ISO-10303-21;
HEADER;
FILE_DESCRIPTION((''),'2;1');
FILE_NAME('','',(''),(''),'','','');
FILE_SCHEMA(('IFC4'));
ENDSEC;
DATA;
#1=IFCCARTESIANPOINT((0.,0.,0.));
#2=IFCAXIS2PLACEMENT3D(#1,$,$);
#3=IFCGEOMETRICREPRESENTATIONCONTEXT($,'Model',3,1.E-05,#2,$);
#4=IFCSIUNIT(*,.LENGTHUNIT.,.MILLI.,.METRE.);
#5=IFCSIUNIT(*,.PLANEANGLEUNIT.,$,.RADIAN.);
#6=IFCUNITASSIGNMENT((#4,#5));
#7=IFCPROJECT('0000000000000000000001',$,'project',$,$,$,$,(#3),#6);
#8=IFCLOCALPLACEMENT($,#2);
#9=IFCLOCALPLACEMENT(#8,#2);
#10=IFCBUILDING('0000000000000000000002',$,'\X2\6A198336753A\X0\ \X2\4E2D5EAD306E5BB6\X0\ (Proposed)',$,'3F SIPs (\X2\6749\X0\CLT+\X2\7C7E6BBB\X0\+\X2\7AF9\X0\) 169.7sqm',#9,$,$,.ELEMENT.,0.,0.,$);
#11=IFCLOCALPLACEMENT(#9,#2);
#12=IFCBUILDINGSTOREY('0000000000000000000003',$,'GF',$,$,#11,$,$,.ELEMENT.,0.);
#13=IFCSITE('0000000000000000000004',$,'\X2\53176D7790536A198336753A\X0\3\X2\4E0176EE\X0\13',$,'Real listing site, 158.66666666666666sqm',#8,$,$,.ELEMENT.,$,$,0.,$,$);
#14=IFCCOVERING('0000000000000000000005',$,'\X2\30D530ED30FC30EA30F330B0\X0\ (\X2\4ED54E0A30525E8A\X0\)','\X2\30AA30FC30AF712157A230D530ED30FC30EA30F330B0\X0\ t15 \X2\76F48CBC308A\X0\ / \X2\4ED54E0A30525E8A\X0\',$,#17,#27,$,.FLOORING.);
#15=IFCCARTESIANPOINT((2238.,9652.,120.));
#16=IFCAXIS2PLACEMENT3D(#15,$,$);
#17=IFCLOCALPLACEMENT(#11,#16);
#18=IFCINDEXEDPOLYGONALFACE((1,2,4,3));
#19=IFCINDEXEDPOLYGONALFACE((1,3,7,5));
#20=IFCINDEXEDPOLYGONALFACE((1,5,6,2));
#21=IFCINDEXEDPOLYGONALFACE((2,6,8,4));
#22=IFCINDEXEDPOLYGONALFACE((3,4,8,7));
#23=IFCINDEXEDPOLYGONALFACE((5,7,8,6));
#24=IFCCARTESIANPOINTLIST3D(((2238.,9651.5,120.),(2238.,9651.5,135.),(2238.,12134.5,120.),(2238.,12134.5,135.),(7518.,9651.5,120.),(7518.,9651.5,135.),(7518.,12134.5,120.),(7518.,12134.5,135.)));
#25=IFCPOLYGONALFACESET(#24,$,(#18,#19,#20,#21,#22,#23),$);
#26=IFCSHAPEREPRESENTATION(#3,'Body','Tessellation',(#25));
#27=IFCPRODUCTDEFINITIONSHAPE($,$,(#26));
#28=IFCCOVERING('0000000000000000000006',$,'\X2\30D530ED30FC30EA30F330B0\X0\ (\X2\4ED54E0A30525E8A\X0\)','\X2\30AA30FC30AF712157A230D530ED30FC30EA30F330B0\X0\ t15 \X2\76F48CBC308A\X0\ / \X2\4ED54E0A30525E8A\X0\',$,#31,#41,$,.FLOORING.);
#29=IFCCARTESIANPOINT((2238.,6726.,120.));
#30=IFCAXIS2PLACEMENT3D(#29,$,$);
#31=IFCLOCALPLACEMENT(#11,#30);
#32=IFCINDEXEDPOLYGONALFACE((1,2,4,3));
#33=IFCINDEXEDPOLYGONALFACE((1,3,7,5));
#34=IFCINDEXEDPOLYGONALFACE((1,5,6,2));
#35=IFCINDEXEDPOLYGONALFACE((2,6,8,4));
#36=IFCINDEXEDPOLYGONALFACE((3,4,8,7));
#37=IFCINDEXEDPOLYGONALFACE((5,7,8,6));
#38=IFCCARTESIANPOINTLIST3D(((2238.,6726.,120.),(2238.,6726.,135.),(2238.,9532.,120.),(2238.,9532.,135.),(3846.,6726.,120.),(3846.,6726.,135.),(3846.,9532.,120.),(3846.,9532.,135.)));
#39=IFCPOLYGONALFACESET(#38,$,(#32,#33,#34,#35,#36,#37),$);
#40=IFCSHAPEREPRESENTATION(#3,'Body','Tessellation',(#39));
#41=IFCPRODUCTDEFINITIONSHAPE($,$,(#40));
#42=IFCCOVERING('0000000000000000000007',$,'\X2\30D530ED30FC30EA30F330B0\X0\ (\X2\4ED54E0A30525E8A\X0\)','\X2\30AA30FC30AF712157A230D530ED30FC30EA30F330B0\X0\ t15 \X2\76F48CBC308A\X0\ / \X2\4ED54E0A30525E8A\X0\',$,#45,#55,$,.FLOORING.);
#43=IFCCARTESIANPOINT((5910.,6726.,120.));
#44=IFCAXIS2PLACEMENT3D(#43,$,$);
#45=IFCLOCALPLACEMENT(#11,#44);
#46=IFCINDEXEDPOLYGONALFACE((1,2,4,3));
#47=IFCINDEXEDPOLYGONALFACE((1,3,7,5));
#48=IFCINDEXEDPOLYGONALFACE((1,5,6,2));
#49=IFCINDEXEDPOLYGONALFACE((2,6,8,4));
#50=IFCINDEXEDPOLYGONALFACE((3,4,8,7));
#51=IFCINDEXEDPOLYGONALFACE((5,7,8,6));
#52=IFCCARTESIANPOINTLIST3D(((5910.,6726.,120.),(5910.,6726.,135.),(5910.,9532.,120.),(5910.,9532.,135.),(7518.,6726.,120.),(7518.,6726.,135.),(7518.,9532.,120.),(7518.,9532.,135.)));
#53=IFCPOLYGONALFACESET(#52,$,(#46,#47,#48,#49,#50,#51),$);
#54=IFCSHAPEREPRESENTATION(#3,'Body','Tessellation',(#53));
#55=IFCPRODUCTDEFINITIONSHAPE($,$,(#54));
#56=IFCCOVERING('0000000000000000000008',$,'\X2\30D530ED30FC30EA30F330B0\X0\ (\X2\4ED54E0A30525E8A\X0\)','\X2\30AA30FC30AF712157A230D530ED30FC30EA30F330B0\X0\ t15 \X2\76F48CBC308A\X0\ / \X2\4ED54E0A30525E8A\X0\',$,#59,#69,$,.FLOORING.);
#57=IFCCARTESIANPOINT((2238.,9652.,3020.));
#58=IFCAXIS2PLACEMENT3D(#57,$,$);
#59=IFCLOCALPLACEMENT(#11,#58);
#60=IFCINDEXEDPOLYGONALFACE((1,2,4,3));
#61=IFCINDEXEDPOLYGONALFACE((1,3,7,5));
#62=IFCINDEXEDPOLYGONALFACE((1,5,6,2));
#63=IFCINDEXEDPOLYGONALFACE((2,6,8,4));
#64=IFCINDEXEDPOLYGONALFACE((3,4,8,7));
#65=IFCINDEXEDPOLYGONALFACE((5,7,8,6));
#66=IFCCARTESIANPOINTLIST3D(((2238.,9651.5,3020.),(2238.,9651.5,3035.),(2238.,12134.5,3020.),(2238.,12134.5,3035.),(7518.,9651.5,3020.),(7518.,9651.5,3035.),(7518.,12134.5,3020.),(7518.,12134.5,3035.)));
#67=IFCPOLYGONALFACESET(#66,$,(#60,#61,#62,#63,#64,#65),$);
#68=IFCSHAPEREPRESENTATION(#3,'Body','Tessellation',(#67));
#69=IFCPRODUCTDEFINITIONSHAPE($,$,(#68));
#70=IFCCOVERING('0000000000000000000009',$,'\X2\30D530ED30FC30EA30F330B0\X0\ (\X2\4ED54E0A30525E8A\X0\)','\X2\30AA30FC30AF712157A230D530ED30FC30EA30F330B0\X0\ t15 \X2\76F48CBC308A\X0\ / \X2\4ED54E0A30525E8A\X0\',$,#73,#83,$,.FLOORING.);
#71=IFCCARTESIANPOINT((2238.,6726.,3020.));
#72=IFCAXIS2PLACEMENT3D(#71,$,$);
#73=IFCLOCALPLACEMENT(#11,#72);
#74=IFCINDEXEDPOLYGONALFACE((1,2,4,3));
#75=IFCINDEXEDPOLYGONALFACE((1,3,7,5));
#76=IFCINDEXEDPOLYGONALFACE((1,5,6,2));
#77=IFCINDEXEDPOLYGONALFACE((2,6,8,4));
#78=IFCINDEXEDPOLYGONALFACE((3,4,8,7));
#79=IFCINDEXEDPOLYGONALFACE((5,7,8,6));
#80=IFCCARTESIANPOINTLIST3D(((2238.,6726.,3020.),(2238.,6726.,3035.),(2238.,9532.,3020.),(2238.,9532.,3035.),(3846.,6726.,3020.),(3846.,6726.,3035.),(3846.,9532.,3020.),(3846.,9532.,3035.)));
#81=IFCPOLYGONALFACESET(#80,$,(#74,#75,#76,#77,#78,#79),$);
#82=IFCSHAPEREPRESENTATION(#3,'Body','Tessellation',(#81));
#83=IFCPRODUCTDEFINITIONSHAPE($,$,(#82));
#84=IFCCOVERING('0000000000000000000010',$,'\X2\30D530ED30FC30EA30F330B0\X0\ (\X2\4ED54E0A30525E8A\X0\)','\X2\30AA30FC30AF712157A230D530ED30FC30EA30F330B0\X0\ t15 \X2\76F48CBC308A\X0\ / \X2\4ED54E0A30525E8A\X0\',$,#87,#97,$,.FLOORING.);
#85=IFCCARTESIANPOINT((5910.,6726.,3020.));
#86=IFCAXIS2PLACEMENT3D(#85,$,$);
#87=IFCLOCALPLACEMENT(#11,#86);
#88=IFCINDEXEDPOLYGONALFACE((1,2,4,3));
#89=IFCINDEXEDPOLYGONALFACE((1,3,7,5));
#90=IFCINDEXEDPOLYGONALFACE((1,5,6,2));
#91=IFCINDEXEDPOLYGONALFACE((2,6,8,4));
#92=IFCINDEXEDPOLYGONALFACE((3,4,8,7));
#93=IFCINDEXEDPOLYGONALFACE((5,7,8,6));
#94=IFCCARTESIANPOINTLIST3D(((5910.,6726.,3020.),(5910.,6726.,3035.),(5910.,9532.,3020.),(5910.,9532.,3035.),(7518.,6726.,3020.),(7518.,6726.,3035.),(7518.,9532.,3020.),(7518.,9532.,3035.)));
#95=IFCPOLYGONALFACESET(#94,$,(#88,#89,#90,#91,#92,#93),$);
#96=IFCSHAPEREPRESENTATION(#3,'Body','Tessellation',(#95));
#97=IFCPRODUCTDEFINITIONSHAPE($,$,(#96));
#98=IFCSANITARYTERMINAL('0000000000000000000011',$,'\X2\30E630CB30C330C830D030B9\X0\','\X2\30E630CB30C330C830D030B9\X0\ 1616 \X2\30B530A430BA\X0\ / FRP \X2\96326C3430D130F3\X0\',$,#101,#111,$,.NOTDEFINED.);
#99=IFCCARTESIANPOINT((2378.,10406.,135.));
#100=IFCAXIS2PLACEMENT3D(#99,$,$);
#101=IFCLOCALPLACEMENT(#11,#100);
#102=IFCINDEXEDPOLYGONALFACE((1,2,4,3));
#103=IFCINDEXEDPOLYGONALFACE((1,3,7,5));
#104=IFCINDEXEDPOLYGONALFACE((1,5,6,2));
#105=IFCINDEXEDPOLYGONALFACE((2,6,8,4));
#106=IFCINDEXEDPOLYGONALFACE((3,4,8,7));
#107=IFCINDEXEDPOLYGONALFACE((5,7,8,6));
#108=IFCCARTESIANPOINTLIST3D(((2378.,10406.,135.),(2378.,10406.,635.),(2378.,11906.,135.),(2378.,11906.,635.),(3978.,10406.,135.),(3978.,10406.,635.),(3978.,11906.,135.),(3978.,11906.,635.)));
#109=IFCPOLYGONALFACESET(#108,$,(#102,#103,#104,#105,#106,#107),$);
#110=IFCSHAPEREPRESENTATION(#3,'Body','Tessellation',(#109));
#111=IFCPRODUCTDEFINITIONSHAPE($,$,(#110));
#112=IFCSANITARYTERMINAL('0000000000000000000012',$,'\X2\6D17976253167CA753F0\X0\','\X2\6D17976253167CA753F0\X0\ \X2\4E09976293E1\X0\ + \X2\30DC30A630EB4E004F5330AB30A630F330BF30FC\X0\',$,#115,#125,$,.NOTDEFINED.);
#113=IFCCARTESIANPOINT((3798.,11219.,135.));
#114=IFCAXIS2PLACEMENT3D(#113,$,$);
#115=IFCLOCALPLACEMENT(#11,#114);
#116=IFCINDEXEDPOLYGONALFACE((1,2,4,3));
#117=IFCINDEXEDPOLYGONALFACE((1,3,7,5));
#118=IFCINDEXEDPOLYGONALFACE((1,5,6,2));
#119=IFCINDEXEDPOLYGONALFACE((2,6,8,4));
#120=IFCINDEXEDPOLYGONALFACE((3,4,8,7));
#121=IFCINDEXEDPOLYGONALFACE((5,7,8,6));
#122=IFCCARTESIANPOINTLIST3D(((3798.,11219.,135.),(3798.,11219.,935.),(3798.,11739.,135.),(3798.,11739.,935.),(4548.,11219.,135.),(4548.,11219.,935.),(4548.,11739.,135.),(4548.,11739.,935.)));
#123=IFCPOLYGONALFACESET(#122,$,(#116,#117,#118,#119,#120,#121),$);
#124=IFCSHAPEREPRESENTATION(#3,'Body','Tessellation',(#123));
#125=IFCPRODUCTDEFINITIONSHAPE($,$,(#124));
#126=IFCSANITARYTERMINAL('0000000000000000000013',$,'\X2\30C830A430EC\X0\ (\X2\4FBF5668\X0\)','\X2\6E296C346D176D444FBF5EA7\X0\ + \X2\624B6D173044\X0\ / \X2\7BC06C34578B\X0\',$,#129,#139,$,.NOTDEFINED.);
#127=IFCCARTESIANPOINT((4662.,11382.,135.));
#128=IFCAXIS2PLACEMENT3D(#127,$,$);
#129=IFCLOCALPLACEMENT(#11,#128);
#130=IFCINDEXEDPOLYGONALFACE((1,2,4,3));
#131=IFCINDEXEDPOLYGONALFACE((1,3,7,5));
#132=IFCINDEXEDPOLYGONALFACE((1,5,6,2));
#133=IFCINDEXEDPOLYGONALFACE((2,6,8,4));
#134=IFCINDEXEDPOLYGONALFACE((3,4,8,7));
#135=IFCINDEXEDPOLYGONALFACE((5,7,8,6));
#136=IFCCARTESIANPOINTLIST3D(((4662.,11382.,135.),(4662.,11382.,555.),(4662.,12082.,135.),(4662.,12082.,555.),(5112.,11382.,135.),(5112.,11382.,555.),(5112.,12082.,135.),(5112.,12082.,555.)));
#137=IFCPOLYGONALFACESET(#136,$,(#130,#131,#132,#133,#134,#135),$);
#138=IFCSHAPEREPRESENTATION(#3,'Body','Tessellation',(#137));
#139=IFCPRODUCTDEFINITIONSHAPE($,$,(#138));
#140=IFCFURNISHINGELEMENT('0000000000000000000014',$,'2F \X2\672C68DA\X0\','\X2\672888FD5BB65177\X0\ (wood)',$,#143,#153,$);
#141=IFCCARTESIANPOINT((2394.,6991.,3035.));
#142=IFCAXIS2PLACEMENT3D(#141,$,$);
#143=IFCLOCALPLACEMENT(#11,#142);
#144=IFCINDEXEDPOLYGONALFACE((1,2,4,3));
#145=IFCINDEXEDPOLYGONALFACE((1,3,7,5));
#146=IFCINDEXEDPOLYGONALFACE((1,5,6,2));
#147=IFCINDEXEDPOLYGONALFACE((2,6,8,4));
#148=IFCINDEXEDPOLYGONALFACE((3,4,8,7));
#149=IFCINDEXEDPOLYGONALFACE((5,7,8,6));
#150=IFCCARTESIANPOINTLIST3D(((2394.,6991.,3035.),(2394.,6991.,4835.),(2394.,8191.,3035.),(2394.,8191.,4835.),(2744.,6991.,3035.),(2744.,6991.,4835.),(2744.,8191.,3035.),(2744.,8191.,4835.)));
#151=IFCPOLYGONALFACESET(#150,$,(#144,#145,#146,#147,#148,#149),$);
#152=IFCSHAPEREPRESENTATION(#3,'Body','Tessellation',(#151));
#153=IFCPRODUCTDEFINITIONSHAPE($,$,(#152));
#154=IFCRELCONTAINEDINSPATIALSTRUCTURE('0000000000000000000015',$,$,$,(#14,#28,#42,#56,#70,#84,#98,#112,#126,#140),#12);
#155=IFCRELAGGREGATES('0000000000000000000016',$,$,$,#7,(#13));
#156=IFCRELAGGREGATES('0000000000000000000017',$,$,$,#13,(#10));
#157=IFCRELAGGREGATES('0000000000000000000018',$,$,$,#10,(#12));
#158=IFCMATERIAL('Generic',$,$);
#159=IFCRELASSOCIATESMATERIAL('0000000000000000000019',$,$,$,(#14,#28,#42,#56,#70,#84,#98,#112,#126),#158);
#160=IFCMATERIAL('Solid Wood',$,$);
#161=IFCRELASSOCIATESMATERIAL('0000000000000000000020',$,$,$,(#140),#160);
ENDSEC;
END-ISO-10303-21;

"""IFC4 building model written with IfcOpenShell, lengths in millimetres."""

from ifc_helpers import new_model, si_unit, frame, frame_2d, origin, place, context, project, spatial, rectangle, extrude, material, element, save


model = new_model("IFC4")

# Units and contexts
model_context = context("Model", 3, precision=1e-05, world=origin())
ifc_project = project(units=[si_unit("LENGTHUNIT", "METRE", prefix="MILLI"), si_unit("PLANEANGLEUNIT", "RADIAN")], contexts=[model_context])

# Site, building, storey
site_placement = place(None, origin())
site = spatial("IfcSite", under=ifc_project, at=site_placement, Name="北海道標茶町3丁目13", ObjectType="Real listing site, 158.66666666666666sqm", CompositionType="ELEMENT", RefElevation=0.0)
building_placement = place(site_placement, origin())
building = spatial("IfcBuilding", under=site, at=building_placement, Name="標茶町 中庭の家 (Proposed)", ObjectType="3F SIPs (杉CLT+籾殻+竹) 169.7sqm", CompositionType="ELEMENT", ElevationOfRefHeight=0.0, ElevationOfTerrain=0.0)
storey_placement = place(building_placement, origin())
storey = spatial("IfcBuildingStorey", under=building, at=storey_placement, Name="GF", CompositionType="ELEMENT", Elevation=0.0)

# Shared definitions
ifc_material_1 = material(Name="Solid Wood")

# Coverings
ifc_material_2 = material(Name="Generic")
covering_1_placement = place(storey_placement, frame((2238.0, 9652.0, 120.0)))
element("IfcCovering", 1, at=covering_1_placement, inside=storey, material=ifc_material_2, Name="フローリング (仕上げ床)", Description="オーク無垢フローリング t15 直貼り / 仕上げ床", PredefinedType="FLOORING", context=model_context, shape_type="SweptSolid", body=[
    extrude(rectangle(XDim=5280.0, YDim=2483.0, at=frame_2d((2640.0, 1241.0))), frame((2238.0, 9652.0, 120.0)), (0.0, 0.0, 1.0), 15.0),
])
covering_2_placement = place(storey_placement, frame((2238.0, 6726.0, 120.0)))
element("IfcCovering", 2, at=covering_2_placement, inside=storey, material=ifc_material_2, Name="フローリング (仕上げ床)", Description="オーク無垢フローリング t15 直貼り / 仕上げ床", PredefinedType="FLOORING", context=model_context, shape_type="SweptSolid", body=[
    extrude(rectangle(XDim=1608.0, YDim=2806.0, at=frame_2d((804.0, 1403.0))), frame((2238.0, 6726.0, 120.0)), (0.0, 0.0, 1.0), 15.0),
])
covering_3_placement = place(storey_placement, frame((5910.0, 6726.0, 120.0)))
element("IfcCovering", 3, at=covering_3_placement, inside=storey, material=ifc_material_2, Name="フローリング (仕上げ床)", Description="オーク無垢フローリング t15 直貼り / 仕上げ床", PredefinedType="FLOORING", context=model_context, shape_type="SweptSolid", body=[
    extrude(rectangle(XDim=1608.0, YDim=2806.0, at=frame_2d((804.0, 1403.0))), frame((5910.0, 6726.0, 120.0)), (0.0, 0.0, 1.0), 15.0),
])
covering_4_placement = place(storey_placement, frame((2238.0, 9652.0, 3020.0)))
element("IfcCovering", 4, at=covering_4_placement, inside=storey, material=ifc_material_2, Name="フローリング (仕上げ床)", Description="オーク無垢フローリング t15 直貼り / 仕上げ床", PredefinedType="FLOORING", context=model_context, shape_type="SweptSolid", body=[
    extrude(rectangle(XDim=5280.0, YDim=2483.0, at=frame_2d((2640.0, 1241.0))), frame((2238.0, 9652.0, 3020.0)), (0.0, 0.0, 1.0), 15.0),
])
covering_5_placement = place(storey_placement, frame((2238.0, 6726.0, 3020.0)))
element("IfcCovering", 5, at=covering_5_placement, inside=storey, material=ifc_material_2, Name="フローリング (仕上げ床)", Description="オーク無垢フローリング t15 直貼り / 仕上げ床", PredefinedType="FLOORING", context=model_context, shape_type="SweptSolid", body=[
    extrude(rectangle(XDim=1608.0, YDim=2806.0, at=frame_2d((804.0, 1403.0))), frame((2238.0, 6726.0, 3020.0)), (0.0, 0.0, 1.0), 15.0),
])
covering_6_placement = place(storey_placement, frame((5910.0, 6726.0, 3020.0)))
element("IfcCovering", 6, at=covering_6_placement, inside=storey, material=ifc_material_2, Name="フローリング (仕上げ床)", Description="オーク無垢フローリング t15 直貼り / 仕上げ床", PredefinedType="FLOORING", context=model_context, shape_type="SweptSolid", body=[
    extrude(rectangle(XDim=1608.0, YDim=2806.0, at=frame_2d((804.0, 1403.0))), frame((5910.0, 6726.0, 3020.0)), (0.0, 0.0, 1.0), 15.0),
])

# Sanitary terminals
sanitary_terminal_1_placement = place(storey_placement, frame((2378.0, 10406.0, 135.0)))
element("IfcSanitaryTerminal", 7, at=sanitary_terminal_1_placement, inside=storey, material=ifc_material_2, Name="ユニットバス", Description="ユニットバス 1616 サイズ / FRP 防水パン", PredefinedType="NOTDEFINED", context=model_context, shape_type="SweptSolid", body=[
    extrude(rectangle(XDim=1600.0, YDim=1500.0, at=frame_2d((800.0, 750.0))), frame((2378.0, 10406.0, 135.0)), (0.0, 0.0, 1.0), 500.0),
])
sanitary_terminal_2_placement = place(storey_placement, frame((3798.0, 11219.0, 135.0)))
element("IfcSanitaryTerminal", 8, at=sanitary_terminal_2_placement, inside=storey, material=ifc_material_2, Name="洗面化粧台", Description="洗面化粧台 三面鏡 + ボウル一体カウンター", PredefinedType="NOTDEFINED", context=model_context, shape_type="SweptSolid", body=[
    extrude(rectangle(XDim=750.0, YDim=520.0, at=frame_2d((375.0, 260.0))), frame((3798.0, 11219.0, 135.0)), (0.0, 0.0, 1.0), 800.0),
])
sanitary_terminal_3_placement = place(storey_placement, frame((4662.0, 11382.0, 135.0)))
element("IfcSanitaryTerminal", 9, at=sanitary_terminal_3_placement, inside=storey, material=ifc_material_2, Name="トイレ (便器)", Description="温水洗浄便座 + 手洗い / 節水型", PredefinedType="NOTDEFINED", context=model_context, shape_type="SweptSolid", body=[
    extrude(rectangle(XDim=450.0, YDim=700.0, at=frame_2d((225.0, 350.0))), frame((4662.0, 11382.0, 135.0)), (0.0, 0.0, 1.0), 420.0),
])

# Furnishing element
furnishing_placement = place(storey_placement, frame((2394.0, 6991.0, 3035.0)))
element("IfcFurnishingElement", 10, at=furnishing_placement, inside=storey, material=ifc_material_1, Name="2F 本棚", Description="木製家具 (wood)", context=model_context, shape_type="SweptSolid", body=[
    extrude(rectangle(XDim=350.0, YDim=1200.0, at=frame_2d((175.0, 600.0))), frame((2394.0, 6991.0, 3035.0)), (0.0, 0.0, 1.0), 1800.0),
])

save(model, "model.ifc")
